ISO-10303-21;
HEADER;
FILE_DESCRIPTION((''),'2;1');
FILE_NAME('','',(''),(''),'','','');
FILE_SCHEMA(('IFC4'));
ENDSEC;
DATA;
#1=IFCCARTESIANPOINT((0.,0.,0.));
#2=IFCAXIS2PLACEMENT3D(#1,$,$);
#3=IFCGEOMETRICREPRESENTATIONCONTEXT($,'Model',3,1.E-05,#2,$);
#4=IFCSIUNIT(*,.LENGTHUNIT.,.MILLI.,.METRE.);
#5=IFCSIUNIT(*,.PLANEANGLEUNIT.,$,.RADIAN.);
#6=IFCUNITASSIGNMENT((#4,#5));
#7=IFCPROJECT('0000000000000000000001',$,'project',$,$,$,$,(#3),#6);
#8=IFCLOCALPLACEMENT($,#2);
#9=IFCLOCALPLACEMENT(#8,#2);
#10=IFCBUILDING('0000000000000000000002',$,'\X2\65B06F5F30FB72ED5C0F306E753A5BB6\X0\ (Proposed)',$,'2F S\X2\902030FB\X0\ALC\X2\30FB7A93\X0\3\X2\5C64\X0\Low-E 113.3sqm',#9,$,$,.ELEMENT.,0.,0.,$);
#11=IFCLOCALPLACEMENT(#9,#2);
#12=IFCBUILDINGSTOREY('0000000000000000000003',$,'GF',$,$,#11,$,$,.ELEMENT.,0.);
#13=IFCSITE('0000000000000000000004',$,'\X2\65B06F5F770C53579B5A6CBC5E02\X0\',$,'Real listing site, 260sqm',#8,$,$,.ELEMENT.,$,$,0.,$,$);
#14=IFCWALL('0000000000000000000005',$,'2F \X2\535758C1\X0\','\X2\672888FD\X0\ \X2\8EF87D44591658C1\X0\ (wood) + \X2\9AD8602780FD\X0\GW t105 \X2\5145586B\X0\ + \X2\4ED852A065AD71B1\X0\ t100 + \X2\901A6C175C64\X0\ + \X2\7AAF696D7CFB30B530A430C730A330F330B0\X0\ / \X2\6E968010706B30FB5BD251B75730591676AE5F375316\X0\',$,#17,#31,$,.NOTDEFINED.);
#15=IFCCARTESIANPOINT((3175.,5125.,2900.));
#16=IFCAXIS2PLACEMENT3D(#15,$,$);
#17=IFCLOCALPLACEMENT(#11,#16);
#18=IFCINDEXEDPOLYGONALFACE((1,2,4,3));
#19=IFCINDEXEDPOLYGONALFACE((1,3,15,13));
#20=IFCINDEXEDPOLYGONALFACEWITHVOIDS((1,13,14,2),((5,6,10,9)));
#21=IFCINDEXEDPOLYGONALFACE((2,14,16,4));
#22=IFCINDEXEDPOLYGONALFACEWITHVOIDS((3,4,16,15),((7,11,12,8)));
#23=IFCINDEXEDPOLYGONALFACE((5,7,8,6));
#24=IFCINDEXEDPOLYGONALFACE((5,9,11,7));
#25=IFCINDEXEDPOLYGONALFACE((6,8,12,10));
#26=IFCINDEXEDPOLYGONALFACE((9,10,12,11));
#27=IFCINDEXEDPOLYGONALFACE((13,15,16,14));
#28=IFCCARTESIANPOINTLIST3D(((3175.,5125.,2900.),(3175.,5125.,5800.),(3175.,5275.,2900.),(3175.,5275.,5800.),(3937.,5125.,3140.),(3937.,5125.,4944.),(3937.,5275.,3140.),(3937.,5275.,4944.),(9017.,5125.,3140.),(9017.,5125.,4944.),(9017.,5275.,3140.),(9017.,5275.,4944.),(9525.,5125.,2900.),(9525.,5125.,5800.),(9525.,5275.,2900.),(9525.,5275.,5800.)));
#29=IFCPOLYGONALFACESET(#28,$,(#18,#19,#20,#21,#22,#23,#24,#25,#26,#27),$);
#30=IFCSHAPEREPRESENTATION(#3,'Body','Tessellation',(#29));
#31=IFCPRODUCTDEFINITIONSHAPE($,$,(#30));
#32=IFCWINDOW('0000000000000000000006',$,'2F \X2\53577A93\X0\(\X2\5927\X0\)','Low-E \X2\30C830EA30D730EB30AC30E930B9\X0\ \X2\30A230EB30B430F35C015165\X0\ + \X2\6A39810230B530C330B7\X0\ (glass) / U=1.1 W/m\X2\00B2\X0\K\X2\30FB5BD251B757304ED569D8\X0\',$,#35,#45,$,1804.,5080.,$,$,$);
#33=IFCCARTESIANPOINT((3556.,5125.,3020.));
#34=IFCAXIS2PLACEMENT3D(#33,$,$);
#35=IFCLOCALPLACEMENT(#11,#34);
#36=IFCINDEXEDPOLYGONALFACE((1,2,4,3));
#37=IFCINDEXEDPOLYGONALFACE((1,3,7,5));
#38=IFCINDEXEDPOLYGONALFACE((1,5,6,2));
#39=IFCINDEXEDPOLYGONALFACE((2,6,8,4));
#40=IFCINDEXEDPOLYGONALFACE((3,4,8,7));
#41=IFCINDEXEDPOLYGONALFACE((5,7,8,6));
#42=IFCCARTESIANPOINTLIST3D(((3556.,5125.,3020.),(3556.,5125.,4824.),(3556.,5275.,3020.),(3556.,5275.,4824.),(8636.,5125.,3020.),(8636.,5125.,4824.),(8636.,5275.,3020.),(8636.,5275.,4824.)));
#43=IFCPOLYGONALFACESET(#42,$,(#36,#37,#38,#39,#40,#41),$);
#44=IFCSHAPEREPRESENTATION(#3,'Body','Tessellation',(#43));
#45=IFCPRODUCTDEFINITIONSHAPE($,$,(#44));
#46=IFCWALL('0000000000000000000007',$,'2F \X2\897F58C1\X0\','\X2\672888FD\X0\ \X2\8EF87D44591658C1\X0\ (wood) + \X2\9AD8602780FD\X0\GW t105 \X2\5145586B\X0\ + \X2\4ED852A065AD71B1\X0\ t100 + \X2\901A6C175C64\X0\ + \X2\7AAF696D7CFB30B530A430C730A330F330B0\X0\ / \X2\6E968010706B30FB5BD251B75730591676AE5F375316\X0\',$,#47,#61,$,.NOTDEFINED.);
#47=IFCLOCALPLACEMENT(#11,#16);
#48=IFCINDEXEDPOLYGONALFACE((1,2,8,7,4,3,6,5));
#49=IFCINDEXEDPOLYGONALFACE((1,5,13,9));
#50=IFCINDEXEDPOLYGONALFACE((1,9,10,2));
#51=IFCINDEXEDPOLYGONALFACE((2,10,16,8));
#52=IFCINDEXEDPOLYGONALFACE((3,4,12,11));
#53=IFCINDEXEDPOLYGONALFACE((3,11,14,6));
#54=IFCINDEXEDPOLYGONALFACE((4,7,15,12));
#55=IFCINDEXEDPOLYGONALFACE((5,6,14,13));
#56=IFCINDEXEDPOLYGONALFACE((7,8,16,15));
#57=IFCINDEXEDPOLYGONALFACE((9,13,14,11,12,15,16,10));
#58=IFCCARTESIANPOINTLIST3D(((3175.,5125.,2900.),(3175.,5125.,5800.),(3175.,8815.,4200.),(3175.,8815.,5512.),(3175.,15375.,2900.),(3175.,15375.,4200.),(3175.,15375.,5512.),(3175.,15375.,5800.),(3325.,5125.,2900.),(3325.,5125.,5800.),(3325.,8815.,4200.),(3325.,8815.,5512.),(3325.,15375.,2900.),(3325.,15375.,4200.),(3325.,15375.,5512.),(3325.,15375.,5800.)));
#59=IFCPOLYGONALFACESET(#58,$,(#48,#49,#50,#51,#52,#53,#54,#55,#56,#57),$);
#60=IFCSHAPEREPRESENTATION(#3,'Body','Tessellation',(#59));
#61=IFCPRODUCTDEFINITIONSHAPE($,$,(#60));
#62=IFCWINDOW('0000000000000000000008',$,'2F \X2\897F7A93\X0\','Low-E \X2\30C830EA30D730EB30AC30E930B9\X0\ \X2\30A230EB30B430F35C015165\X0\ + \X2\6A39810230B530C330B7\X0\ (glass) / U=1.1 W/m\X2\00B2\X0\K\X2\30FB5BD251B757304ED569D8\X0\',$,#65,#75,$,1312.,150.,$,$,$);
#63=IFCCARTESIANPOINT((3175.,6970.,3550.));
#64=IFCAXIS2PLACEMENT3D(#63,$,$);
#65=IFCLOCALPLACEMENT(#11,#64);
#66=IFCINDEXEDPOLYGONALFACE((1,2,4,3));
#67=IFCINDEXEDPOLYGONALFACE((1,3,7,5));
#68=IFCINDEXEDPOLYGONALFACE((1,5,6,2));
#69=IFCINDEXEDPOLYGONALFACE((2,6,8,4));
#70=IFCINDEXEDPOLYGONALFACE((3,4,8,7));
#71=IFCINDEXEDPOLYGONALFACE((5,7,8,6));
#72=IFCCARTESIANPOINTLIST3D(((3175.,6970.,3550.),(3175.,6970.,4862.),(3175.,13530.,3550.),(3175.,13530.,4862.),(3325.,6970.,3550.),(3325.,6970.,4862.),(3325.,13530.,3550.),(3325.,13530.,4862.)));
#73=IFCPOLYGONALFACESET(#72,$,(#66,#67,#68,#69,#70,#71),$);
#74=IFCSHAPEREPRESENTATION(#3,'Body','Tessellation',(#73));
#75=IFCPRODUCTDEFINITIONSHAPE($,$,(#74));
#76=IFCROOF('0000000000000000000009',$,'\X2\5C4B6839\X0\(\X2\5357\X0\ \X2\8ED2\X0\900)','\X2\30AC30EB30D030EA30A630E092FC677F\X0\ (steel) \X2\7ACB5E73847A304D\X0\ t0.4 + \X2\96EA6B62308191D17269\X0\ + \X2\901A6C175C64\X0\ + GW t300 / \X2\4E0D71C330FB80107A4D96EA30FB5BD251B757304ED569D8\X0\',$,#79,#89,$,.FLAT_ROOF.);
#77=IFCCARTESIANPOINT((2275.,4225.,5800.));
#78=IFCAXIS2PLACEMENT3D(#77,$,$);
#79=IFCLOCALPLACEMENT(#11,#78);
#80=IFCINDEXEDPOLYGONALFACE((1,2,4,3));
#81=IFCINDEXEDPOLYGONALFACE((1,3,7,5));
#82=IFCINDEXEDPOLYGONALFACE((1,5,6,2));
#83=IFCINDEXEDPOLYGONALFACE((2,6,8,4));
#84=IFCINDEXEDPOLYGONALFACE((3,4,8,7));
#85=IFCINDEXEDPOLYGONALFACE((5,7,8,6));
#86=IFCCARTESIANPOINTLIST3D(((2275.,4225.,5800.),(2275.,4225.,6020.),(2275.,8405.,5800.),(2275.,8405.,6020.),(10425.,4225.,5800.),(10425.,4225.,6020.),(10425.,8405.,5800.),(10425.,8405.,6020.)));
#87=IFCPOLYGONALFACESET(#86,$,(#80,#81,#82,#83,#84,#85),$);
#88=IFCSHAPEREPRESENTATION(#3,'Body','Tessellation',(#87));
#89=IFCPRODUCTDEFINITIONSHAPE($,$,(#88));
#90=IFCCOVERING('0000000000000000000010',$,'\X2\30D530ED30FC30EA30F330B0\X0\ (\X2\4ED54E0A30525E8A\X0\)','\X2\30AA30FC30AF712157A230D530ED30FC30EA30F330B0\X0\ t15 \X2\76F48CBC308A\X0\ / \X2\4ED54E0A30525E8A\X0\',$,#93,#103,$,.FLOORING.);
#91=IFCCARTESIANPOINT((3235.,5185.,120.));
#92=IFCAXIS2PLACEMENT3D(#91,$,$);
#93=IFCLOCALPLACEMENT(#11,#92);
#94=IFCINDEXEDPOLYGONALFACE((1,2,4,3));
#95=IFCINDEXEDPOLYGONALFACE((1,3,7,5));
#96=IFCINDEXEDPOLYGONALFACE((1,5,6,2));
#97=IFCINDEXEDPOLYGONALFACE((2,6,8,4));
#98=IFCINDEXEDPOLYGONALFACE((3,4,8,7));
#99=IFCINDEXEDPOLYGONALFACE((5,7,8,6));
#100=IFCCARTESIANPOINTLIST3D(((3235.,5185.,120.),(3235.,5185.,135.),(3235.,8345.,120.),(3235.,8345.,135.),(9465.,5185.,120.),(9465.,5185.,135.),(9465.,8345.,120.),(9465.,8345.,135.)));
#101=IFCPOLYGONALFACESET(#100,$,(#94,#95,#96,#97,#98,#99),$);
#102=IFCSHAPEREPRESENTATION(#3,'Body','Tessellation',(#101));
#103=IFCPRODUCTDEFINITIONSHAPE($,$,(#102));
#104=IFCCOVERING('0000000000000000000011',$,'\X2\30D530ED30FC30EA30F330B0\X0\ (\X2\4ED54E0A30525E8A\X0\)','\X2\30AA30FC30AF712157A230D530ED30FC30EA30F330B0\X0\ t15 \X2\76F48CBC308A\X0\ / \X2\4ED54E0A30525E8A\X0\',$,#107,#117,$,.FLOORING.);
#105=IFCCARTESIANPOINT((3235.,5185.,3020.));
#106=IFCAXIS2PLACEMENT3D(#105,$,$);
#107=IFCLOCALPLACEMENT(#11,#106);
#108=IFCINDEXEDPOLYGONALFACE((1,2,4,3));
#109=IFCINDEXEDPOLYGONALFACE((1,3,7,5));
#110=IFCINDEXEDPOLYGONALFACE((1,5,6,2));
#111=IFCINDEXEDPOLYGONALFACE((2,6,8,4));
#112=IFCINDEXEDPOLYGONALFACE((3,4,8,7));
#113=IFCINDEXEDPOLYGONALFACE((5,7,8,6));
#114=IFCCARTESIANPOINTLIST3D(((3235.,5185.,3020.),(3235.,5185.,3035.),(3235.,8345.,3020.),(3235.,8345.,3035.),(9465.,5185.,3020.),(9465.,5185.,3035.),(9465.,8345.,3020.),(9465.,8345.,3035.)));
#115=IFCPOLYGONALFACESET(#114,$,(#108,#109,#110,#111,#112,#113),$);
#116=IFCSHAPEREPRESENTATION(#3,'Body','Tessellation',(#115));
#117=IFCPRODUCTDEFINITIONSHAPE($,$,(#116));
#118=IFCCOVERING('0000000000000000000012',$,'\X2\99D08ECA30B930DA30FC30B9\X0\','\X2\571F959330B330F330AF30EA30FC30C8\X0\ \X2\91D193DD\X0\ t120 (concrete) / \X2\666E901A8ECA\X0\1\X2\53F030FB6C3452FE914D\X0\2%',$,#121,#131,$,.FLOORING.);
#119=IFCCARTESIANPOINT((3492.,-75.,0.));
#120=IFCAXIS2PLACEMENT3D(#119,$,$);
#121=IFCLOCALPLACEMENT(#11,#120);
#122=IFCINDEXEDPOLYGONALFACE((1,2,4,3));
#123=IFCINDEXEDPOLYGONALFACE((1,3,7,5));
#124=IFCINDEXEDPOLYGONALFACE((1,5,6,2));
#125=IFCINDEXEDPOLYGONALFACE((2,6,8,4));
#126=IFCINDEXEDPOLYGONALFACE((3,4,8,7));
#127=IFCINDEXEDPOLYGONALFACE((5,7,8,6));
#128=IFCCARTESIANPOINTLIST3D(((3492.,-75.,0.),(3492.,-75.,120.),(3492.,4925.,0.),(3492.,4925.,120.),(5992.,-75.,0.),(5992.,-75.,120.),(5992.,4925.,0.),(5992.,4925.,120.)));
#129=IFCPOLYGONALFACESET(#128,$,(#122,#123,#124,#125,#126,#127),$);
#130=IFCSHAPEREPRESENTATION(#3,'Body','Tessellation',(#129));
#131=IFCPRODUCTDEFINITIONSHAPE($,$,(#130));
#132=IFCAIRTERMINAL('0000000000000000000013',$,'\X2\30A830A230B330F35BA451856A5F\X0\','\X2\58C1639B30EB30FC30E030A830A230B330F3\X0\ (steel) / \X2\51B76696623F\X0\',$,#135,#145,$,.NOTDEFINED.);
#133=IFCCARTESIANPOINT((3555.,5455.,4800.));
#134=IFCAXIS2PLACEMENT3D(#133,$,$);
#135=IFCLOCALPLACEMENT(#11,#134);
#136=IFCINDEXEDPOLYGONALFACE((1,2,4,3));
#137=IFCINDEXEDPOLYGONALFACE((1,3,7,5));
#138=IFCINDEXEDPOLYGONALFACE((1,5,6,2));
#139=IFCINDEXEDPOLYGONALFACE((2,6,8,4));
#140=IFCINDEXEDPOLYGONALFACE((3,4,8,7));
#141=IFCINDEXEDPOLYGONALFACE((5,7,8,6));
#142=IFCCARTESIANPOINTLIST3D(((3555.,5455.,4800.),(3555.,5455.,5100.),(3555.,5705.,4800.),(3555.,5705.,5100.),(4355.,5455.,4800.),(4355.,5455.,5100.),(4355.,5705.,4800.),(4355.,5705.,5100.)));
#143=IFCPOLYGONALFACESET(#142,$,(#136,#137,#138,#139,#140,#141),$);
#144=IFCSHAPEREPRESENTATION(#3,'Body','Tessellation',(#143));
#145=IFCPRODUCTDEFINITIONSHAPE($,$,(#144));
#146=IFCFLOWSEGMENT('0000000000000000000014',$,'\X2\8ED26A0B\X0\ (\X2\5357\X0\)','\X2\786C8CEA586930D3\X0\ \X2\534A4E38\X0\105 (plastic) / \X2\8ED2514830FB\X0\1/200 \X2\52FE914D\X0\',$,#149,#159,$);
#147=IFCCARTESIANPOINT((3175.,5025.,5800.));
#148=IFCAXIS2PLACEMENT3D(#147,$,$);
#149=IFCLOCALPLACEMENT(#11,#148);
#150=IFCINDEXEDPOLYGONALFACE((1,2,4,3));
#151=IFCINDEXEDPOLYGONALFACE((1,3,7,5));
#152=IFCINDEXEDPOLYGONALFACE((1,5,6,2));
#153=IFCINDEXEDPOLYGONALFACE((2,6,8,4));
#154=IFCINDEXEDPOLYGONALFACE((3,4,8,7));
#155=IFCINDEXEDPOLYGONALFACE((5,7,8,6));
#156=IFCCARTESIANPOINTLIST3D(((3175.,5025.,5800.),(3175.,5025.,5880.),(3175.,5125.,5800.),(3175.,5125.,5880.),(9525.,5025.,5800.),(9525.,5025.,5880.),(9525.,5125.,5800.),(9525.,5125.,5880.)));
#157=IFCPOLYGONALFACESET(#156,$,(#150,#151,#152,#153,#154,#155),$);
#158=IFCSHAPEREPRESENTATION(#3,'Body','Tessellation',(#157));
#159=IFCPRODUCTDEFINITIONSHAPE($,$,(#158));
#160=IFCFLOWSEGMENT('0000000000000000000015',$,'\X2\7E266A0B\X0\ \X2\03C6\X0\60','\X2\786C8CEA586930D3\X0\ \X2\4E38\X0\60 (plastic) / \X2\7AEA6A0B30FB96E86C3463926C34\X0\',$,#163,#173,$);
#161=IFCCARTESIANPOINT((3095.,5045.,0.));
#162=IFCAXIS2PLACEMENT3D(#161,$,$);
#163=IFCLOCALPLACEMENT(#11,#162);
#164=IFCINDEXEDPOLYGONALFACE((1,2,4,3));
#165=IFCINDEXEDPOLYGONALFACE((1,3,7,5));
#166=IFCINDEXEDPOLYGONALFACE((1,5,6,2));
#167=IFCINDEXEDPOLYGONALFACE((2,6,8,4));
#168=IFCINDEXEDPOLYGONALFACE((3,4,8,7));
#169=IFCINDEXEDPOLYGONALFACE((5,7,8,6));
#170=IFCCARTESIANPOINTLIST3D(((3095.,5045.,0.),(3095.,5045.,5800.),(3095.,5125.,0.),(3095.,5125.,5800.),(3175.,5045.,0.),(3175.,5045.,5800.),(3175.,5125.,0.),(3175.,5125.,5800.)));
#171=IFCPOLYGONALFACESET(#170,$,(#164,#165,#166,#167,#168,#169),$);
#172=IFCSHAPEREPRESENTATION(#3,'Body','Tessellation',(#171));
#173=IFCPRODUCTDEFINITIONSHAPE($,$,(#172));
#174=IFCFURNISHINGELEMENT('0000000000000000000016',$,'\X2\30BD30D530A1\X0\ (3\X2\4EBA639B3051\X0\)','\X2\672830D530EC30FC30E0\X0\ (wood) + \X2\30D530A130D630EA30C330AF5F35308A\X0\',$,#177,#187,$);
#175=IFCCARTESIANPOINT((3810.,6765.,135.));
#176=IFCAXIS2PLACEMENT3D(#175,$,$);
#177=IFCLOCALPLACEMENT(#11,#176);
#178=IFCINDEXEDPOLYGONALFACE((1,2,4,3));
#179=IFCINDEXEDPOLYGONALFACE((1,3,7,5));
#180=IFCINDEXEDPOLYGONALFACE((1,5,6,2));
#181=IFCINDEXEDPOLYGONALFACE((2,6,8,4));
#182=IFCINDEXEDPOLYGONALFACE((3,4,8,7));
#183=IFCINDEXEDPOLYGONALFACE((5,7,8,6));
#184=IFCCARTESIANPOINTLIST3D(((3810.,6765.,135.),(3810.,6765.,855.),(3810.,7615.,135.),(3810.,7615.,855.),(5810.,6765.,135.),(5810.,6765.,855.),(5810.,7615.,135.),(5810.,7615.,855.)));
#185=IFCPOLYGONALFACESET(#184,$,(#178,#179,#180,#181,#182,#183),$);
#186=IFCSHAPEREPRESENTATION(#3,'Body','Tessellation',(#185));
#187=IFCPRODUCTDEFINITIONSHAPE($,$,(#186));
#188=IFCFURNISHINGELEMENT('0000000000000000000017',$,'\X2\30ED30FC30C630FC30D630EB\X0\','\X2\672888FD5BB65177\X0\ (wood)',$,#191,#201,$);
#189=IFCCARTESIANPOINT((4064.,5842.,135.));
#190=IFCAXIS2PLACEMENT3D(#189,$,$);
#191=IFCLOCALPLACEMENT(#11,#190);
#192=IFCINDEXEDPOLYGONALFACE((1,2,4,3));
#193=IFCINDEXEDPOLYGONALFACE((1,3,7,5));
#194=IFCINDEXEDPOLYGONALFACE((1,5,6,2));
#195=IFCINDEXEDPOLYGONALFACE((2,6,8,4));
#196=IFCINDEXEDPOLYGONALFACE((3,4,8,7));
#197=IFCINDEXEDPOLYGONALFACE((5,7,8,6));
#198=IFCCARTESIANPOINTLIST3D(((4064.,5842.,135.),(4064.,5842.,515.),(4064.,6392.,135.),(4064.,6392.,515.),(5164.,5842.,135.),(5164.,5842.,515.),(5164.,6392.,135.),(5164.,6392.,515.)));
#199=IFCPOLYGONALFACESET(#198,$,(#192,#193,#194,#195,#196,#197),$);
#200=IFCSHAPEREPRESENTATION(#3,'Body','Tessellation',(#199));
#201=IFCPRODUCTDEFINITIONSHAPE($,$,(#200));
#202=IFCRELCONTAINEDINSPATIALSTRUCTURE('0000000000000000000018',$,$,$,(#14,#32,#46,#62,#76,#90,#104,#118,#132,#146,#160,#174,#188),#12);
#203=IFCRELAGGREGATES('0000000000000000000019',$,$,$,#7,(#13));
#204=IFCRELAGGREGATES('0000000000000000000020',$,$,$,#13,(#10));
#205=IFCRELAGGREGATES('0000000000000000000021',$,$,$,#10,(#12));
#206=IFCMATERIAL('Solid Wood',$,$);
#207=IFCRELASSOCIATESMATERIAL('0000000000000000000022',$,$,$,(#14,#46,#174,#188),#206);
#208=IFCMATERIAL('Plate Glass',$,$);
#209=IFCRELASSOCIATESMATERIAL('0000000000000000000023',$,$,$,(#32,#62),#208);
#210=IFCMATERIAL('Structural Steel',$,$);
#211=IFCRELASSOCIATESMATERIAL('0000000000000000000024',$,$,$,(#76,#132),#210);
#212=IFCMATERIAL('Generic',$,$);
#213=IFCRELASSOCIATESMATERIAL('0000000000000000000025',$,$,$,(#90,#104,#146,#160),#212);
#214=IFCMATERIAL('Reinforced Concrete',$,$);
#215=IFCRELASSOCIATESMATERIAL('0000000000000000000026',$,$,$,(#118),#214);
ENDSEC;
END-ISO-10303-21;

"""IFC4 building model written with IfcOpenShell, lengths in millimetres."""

from ifc_helpers import new_model, si_unit, frame, frame_2d, origin, place, context, project, spatial, rectangle, extrude, material, element, fill, save


model = new_model("IFC4")

# Units and contexts
model_context = context("Model", 3, precision=1e-05, world=origin())
ifc_project = project(units=[si_unit("LENGTHUNIT", "METRE", prefix="MILLI"), si_unit("PLANEANGLEUNIT", "RADIAN")], contexts=[model_context])

# Site, building, storey
site_placement = place(None, origin())
site = spatial("IfcSite", under=ifc_project, at=site_placement, Name="新潟県南魚沼市", ObjectType="Real listing site, 260sqm", CompositionType="ELEMENT", RefElevation=0.0)
building_placement = place(site_placement, origin())
building = spatial("IfcBuilding", under=site, at=building_placement, Name="新潟・狭小の町家 (Proposed)", ObjectType="2F S造・ALC・窓3層Low-E 113.3sqm", CompositionType="ELEMENT", ElevationOfRefHeight=0.0, ElevationOfTerrain=0.0)
storey_placement = place(building_placement, origin())
storey = spatial("IfcBuildingStorey", under=building, at=storey_placement, Name="GF", CompositionType="ELEMENT", Elevation=0.0)

# Shared definitions
ifc_material_1 = material(Name="Solid Wood")

# Shared definitions
ifc_material_2 = material(Name="Reinforced Concrete")

# Shared definitions
ifc_material_3 = material(Name="Plate Glass")

# Walls, openings, windows
wall_1_placement = place(storey_placement, frame((3175.0, 5125.0, 2900.0)))
wall_1 = element("IfcWall", 1, at=wall_1_placement, inside=storey, material=ifc_material_1, Name="2F 南壁", Description="木製 軸組外壁 (wood) + 高性能GW t105 充填 + 付加断熱 t100 + 通気層 + 窯業系サイディング / 準耐火・寒冷地外皮強化", PredefinedType="NOTDEFINED", context=model_context, shape_type="SweptSolid", body=[
    extrude(rectangle(XDim=6350.0, YDim=150.0, at=frame_2d((3175.0, 75.0))), frame((3175.0, 5125.0, 2900.0)), (0.0, 0.0, 1.0), 2900.0),
])
opening_1_placement = place(storey_placement, frame((3556.0, 5125.0, 3020.0)))
opening_1 = element("IfcOpeningElement", 2, at=opening_1_placement, cuts=wall_1, PredefinedType="NOTDEFINED", context=model_context, shape_type="SweptSolid", body=[
    extrude(rectangle(XDim=5080.0, YDim=150.0, at=frame_2d((2540.0, 75.0))), frame((3556.0, 5125.0, 3020.0)), (0.0, 0.0, 1.0), 1804.0),
])
window_1_placement = place(storey_placement, frame((3556.0, 5125.0, 3020.0)))
window_1 = element("IfcWindow", 3, at=window_1_placement, inside=storey, material=ifc_material_3, Name="2F 南窓(大)", Description="Low-E トリプルガラス アルゴン封入 + 樹脂サッシ (glass) / U=1.1 W/m²K・寒冷地仕様", OverallHeight=1804.0, OverallWidth=5080.0, context=model_context, shape_type="SweptSolid", body=[
    extrude(rectangle(XDim=5080.0, YDim=150.0, at=frame_2d((2540.0, 75.0))), frame((3556.0, 5125.0, 3020.0)), (0.0, 0.0, 1.0), 1804.0),
])
fill(opening_1, window_1)
wall_2_placement = place(storey_placement, frame((3175.0, 5125.0, 2900.0)))
wall_2 = element("IfcWall", 4, at=wall_2_placement, inside=storey, material=ifc_material_1, Name="2F 西壁", Description="木製 軸組外壁 (wood) + 高性能GW t105 充填 + 付加断熱 t100 + 通気層 + 窯業系サイディング / 準耐火・寒冷地外皮強化", PredefinedType="NOTDEFINED", context=model_context, shape_type="SweptSolid", body=[
    extrude(rectangle(XDim=150.0, YDim=10250.0, at=frame_2d((75.0, 5125.0))), frame((3175.0, 5125.0, 2900.0)), (0.0, 0.0, 1.0), 2900.0),
])
opening_2_placement = place(storey_placement, frame((3175.0, 6970.0, 3550.0)))
opening_2 = element("IfcOpeningElement", 5, at=opening_2_placement, cuts=wall_2, PredefinedType="NOTDEFINED", context=model_context, shape_type="SweptSolid", body=[
    extrude(rectangle(XDim=150.0, YDim=6560.0, at=frame_2d((75.0, 3280.0))), frame((3175.0, 6970.0, 3550.0)), (0.0, 0.0, 1.0), 1312.0),
])
window_2_placement = place(storey_placement, frame((3175.0, 6970.0, 3550.0)))
window_2 = element("IfcWindow", 6, at=window_2_placement, inside=storey, material=ifc_material_3, Name="2F 西窓", Description="Low-E トリプルガラス アルゴン封入 + 樹脂サッシ (glass) / U=1.1 W/m²K・寒冷地仕様", OverallHeight=1312.0, OverallWidth=150.0, context=model_context, shape_type="SweptSolid", body=[
    extrude(rectangle(XDim=150.0, YDim=6560.0, at=frame_2d((75.0, 3280.0))), frame((3175.0, 6970.0, 3550.0)), (0.0, 0.0, 1.0), 1312.0),
])
fill(opening_2, window_2)

# Roof
ifc_material_4 = material(Name="Structural Steel")
for number, where, name in (
    (7, (2275.0, 4225.0, 5800.0), "屋根(南 軒900)"),
):
    element("IfcRoof", number, at=place(storey_placement, frame(where)), inside=storey, material=ifc_material_4, Name=name, Description="ガルバリウム鋼板 (steel) 立平葺き t0.4 + 雪止め金物 + 通気層 + GW t300 / 不燃・耐積雪・寒冷地仕様", PredefinedType="FLAT_ROOF", context=model_context, shape_type="SweptSolid", body=[
        extrude(rectangle(XDim=8150.0, YDim=4180.0, at=frame_2d((4075.0, 2090.0))), frame((2275.0, 4225.0, 5800.0)), (0.0, 0.0, 1.0), 220.0),
    ])

# Coverings
ifc_material_5 = material(Name="Generic")
covering_1_placement = place(storey_placement, frame((3235.0, 5185.0, 120.0)))
element("IfcCovering", 8, at=covering_1_placement, inside=storey, material=ifc_material_5, Name="フローリング (仕上げ床)", Description="オーク無垢フローリング t15 直貼り / 仕上げ床", PredefinedType="FLOORING", context=model_context, shape_type="SweptSolid", body=[
    extrude(rectangle(XDim=6230.0, YDim=3160.0, at=frame_2d((3115.0, 1580.0))), frame((3235.0, 5185.0, 120.0)), (0.0, 0.0, 1.0), 15.0),
])
covering_2_placement = place(storey_placement, frame((3235.0, 5185.0, 3020.0)))
element("IfcCovering", 9, at=covering_2_placement, inside=storey, material=ifc_material_5, Name="フローリング (仕上げ床)", Description="オーク無垢フローリング t15 直貼り / 仕上げ床", PredefinedType="FLOORING", context=model_context, shape_type="SweptSolid", body=[
    extrude(rectangle(XDim=6230.0, YDim=3160.0, at=frame_2d((3115.0, 1580.0))), frame((3235.0, 5185.0, 3020.0)), (0.0, 0.0, 1.0), 15.0),
])
covering_3_placement = place(storey_placement, frame((3492.0, -75.0, 0.0)))
element("IfcCovering", 10, at=covering_3_placement, inside=storey, material=ifc_material_2, Name="駐車スペース", Description="土間コンクリート 金鏝 t120 (concrete) / 普通車1台・水勾配2%", PredefinedType="FLOORING", context=model_context, shape_type="SweptSolid", body=[
    extrude(rectangle(XDim=2500.0, YDim=5000.0, at=frame_2d((1250.0, 2500.0))), frame((3492.0, -75.0, 0.0)), (0.0, 0.0, 1.0), 120.0),
])

# Air terminal
air_terminal_placement = place(storey_placement, frame((3555.0, 5455.0, 4800.0)))
element("IfcAirTerminal", 11, at=air_terminal_placement, inside=storey, material=ifc_material_4, Name="エアコン室内機", Description="壁掛ルームエアコン (steel) / 冷暖房", PredefinedType="NOTDEFINED", context=model_context, shape_type="SweptSolid", body=[
    extrude(rectangle(XDim=800.0, YDim=250.0, at=frame_2d((400.0, 125.0))), frame((3555.0, 5455.0, 4800.0)), (0.0, 0.0, 1.0), 300.0),
])

# Flow segments
flow_segment_1_placement = place(storey_placement, frame((3175.0, 5025.0, 5800.0)))
element("IfcFlowSegment", 12, at=flow_segment_1_placement, inside=storey, material=ifc_material_5, Name="軒樋 (南)", Description="硬質塩ビ 半丸105 (plastic) / 軒先・1/200 勾配", context=model_context, shape_type="SweptSolid", body=[
    extrude(rectangle(XDim=6350.0, YDim=100.0, at=frame_2d((3175.0, 50.0))), frame((3175.0, 5025.0, 5800.0)), (0.0, 0.0, 1.0), 80.0),
])
flow_segment_2_placement = place(storey_placement, frame((3095.0, 5045.0, 0.0)))
element("IfcFlowSegment", 13, at=flow_segment_2_placement, inside=storey, material=ifc_material_5, Name="縦樋 φ60", Description="硬質塩ビ 丸60 (plastic) / 竪樋・雨水排水", context=model_context, shape_type="SweptSolid", body=[
    extrude(rectangle(XDim=80.0, YDim=80.0, at=frame_2d((40.0, 40.0))), frame((3095.0, 5045.0, 0.0)), (0.0, 0.0, 1.0), 5800.0),
])

# Furnishing elements
furnishing_1_placement = place(storey_placement, frame((3810.0, 6765.0, 135.0)))
element("IfcFurnishingElement", 14, at=furnishing_1_placement, inside=storey, material=ifc_material_1, Name="ソファ (3人掛け)", Description="木フレーム (wood) + ファブリック張り", context=model_context, shape_type="SweptSolid", body=[
    extrude(rectangle(XDim=2000.0, YDim=850.0, at=frame_2d((1000.0, 425.0))), frame((3810.0, 6765.0, 135.0)), (0.0, 0.0, 1.0), 720.0),
])
furnishing_2_placement = place(storey_placement, frame((4064.0, 5842.0, 135.0)))
element("IfcFurnishingElement", 15, at=furnishing_2_placement, inside=storey, material=ifc_material_1, Name="ローテーブル", Description="木製家具 (wood)", context=model_context, shape_type="SweptSolid", body=[
    extrude(rectangle(XDim=1100.0, YDim=550.0, at=frame_2d((550.0, 275.0))), frame((4064.0, 5842.0, 135.0)), (0.0, 0.0, 1.0), 380.0),
])

save(model, "model.ifc")
